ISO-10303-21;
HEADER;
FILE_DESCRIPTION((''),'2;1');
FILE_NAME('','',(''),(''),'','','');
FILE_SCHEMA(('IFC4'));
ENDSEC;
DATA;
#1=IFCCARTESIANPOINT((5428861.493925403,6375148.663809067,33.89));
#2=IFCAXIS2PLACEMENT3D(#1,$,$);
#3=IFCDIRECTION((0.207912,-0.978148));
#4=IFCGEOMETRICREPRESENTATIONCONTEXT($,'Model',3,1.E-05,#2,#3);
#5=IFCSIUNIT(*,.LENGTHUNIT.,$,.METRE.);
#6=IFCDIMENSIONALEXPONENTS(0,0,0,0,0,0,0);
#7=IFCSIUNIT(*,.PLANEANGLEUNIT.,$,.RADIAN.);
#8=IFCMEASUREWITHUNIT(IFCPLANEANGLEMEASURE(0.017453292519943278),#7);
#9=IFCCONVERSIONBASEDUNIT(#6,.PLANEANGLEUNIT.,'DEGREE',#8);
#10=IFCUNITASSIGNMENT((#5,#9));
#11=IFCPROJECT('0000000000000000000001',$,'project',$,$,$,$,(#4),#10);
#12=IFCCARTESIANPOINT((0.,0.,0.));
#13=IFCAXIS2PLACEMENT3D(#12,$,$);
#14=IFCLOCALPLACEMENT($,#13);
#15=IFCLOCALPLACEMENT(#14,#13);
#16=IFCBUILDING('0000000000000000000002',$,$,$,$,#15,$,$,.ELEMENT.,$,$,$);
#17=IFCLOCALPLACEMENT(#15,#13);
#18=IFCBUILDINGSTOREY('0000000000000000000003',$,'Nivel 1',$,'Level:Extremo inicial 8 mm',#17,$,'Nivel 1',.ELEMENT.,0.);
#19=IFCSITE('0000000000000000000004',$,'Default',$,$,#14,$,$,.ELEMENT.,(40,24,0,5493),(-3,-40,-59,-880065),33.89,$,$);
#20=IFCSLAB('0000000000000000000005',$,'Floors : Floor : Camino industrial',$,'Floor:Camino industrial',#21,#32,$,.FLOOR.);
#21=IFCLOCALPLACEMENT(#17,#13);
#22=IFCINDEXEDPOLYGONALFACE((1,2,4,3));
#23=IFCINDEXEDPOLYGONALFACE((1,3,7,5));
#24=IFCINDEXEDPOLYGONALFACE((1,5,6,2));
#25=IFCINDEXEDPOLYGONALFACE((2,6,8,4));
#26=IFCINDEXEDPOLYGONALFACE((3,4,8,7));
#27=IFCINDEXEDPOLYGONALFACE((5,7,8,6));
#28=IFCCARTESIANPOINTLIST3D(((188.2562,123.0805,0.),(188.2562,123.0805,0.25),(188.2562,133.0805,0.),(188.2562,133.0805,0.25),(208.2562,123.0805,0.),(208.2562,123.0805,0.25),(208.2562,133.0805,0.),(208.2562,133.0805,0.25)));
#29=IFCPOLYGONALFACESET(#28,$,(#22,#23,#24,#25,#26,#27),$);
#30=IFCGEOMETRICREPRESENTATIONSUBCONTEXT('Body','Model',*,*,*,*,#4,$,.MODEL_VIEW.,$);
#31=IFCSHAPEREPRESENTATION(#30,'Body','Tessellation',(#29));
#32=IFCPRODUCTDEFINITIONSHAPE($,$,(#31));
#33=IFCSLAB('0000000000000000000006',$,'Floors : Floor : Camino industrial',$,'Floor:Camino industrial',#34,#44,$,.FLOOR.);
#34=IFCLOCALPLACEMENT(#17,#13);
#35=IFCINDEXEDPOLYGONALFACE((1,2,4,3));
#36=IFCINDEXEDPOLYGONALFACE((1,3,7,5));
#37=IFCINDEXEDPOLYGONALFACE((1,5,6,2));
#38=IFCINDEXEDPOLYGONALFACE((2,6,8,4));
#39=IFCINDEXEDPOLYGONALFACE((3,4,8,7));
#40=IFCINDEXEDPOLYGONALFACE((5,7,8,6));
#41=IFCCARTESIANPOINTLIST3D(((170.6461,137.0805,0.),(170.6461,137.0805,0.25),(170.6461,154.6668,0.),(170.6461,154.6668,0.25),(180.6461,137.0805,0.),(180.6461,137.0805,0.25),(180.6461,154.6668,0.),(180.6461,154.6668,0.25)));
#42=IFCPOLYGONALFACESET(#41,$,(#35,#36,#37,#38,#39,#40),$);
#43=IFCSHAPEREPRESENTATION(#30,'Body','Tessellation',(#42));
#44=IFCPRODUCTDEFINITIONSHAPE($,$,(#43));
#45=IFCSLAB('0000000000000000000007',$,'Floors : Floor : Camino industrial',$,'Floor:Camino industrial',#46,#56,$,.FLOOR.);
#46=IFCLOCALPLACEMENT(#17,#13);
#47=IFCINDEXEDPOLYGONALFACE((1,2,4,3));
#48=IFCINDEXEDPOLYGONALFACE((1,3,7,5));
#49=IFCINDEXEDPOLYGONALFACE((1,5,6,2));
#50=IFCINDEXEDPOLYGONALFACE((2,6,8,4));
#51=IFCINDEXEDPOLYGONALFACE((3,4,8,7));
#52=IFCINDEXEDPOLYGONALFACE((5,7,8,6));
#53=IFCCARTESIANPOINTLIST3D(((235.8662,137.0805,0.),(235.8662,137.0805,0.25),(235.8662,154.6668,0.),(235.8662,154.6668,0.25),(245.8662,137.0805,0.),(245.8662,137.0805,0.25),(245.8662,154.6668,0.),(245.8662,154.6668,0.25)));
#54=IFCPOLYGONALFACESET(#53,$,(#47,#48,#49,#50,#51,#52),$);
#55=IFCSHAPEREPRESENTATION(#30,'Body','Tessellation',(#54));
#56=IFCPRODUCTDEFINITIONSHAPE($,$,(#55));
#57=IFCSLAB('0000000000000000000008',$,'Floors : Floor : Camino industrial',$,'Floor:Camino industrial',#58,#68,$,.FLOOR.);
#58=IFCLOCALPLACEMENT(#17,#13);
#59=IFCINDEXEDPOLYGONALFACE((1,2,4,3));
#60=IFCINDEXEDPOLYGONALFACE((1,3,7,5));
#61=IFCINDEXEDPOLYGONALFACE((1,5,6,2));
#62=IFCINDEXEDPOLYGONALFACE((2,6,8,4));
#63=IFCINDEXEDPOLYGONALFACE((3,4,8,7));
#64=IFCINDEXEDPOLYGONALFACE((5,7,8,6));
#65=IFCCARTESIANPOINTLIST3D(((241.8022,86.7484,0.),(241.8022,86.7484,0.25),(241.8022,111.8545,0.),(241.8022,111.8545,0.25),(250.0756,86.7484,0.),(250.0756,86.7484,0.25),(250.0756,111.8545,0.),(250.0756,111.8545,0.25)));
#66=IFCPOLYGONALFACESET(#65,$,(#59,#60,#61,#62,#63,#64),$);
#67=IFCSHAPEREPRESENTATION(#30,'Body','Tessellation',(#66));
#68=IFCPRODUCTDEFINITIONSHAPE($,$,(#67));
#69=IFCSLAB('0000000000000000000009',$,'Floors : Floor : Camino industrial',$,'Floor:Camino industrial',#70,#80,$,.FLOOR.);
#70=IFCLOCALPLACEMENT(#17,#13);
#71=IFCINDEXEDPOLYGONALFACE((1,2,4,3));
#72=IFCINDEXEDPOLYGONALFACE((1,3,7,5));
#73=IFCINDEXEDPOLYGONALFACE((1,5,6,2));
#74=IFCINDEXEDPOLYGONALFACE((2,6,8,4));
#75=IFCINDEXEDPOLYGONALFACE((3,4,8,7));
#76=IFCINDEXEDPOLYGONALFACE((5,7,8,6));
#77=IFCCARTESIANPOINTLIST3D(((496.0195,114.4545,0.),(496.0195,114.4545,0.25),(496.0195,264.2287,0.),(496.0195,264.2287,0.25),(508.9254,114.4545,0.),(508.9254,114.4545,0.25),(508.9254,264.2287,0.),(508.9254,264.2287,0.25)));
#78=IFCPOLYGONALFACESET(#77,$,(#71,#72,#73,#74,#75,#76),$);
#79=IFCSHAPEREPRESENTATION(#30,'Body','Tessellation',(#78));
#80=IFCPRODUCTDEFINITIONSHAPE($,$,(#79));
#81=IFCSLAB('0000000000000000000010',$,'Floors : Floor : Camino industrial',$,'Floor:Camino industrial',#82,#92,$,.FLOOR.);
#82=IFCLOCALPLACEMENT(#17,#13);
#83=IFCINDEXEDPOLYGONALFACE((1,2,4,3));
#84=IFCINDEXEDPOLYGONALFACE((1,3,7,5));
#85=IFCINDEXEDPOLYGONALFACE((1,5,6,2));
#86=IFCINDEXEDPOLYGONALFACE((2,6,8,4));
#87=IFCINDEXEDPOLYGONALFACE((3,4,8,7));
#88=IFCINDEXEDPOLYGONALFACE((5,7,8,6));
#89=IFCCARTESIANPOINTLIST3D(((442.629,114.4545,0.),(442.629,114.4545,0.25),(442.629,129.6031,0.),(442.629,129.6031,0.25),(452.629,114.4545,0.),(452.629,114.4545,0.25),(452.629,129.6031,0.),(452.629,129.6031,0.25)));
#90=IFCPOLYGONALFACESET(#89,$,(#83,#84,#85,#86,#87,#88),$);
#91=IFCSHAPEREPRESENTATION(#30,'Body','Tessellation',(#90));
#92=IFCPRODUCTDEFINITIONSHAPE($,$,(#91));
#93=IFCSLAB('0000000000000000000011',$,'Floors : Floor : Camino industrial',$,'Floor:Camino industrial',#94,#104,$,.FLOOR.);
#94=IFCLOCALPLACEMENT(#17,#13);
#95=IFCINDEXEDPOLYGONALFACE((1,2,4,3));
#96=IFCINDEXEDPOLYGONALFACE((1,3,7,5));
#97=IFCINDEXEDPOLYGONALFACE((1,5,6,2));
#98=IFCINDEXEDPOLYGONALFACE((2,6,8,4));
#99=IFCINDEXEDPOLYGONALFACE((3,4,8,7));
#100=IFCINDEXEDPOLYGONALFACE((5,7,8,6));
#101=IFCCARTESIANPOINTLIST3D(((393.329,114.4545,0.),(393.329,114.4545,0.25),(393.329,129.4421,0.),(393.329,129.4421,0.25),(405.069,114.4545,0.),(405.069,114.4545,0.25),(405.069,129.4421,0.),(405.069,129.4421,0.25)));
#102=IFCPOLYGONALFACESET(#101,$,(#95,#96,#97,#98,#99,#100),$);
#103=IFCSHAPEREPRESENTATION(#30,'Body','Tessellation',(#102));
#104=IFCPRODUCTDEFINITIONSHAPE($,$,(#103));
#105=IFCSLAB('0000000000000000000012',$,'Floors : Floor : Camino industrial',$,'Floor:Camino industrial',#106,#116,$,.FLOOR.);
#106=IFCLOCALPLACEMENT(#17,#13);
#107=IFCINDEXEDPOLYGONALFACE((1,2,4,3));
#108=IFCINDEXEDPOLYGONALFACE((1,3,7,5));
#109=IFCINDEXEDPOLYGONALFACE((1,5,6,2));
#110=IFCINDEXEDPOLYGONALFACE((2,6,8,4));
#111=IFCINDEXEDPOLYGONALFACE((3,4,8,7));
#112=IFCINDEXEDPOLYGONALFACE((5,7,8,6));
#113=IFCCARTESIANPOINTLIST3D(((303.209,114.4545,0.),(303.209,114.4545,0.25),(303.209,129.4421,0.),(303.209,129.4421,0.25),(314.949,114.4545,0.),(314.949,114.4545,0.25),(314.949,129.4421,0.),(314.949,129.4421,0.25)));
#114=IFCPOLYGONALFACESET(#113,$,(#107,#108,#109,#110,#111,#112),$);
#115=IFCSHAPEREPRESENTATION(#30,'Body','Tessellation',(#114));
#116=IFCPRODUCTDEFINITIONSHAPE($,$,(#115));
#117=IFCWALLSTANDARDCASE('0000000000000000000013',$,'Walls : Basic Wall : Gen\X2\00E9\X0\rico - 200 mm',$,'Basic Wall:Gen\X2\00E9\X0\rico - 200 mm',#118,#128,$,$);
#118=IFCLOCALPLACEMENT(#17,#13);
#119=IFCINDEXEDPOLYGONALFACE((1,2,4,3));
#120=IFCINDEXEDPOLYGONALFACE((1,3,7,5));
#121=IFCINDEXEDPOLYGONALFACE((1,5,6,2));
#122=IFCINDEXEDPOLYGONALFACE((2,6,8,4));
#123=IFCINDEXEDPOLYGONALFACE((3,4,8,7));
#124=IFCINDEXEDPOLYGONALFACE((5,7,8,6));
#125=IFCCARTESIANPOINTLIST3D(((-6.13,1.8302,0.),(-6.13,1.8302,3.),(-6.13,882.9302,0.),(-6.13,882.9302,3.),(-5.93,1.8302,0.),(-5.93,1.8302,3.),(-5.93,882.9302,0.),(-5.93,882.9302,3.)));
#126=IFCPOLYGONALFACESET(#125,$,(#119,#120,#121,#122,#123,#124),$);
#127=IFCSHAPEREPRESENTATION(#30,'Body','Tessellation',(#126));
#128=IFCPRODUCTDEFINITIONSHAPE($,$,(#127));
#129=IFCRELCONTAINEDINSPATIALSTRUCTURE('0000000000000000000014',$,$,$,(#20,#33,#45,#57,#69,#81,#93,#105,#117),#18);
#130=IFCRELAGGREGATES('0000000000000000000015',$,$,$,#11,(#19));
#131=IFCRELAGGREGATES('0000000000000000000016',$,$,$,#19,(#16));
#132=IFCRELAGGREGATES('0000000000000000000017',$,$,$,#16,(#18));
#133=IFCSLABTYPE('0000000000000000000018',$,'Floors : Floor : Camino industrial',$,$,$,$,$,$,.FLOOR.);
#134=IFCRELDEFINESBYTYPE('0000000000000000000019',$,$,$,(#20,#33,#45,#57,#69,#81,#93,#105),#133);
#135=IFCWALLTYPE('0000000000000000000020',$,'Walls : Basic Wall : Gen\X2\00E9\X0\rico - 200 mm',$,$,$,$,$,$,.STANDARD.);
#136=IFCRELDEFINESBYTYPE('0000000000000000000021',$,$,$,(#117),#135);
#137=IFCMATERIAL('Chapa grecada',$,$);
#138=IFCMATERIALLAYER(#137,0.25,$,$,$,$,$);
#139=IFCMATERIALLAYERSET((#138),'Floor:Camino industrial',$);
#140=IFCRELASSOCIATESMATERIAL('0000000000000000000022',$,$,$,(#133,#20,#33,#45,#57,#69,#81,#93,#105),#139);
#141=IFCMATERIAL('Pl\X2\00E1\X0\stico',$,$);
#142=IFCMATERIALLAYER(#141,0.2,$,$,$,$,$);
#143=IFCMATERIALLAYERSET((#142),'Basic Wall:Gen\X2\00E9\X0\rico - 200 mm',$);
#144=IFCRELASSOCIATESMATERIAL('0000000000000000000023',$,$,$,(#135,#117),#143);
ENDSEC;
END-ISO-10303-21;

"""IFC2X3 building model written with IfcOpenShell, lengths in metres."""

from ifc_helpers import new_model, entity, si_unit, converted_unit, direction, frame, frame_2d, origin, origin_2d_with_axis, place, context, subcontext, project, spatial, rectangle, extrude, material, layer, layer_set, layer_usage, type_object, element, save


model = new_model("IFC2X3")

# Units and contexts
model_context = context("Model", 3, precision=1e-05, world=frame((5428861.493925403, 6375148.663809067, 33.89)), true_north=direction((0.207912, -0.978148)))
body_context = subcontext(model_context, "Body", "Model", "MODEL_VIEW")
ifc_project = project(units=[si_unit("LENGTHUNIT", "METRE"), converted_unit("PLANEANGLEUNIT", "DEGREE", entity("IfcPlaneAngleMeasure", 0.017453292519943278), si_unit("PLANEANGLEUNIT", "RADIAN"), dimensions=[0, 0, 0, 0, 0, 0, 0])], contexts=[model_context])

# Site, building, storey
site_placement = place(None, origin())
site = spatial("IfcSite", under=ifc_project, at=site_placement, Name="Default", CompositionType="ELEMENT", RefLatitude=(40, 24, 0, 5493), RefLongitude=(-3, -40, -59, -880065), RefElevation=33.89)
building_placement = place(site_placement, origin())
building = spatial("IfcBuilding", under=site, at=building_placement, CompositionType="ELEMENT")
storey_placement = place(building_placement, origin())
storey = spatial("IfcBuildingStorey", under=building, at=storey_placement, Name="Nivel 1", ObjectType="Level:Extremo inicial 8 mm", LongName="Nivel 1", CompositionType="ELEMENT", Elevation=0.0)

# Slabs
ifc_material_1 = material(Name="Chapa grecada")
ifc_layer_1 = layer(ifc_material_1, 0.25)
ifc_layer_set_1 = layer_set([ifc_layer_1], Name="Floor:Camino industrial")
slab_type = type_object("IfcSlabType", Name="Floors : Floor : Camino industrial", PredefinedType="FLOOR", material=ifc_layer_set_1)
ifc_layer_usage_1 = layer_usage(ifc_layer_set_1, "AXIS3", "POSITIVE", 0.0)
slab_1_placement = place(storey_placement, origin())
element("IfcSlab", 1, at=slab_1_placement, inside=storey, type_object=slab_type, material=ifc_layer_usage_1, Name="Floors : Floor : Camino industrial", ObjectType="Floor:Camino industrial", PredefinedType="FLOOR", context=body_context, shape_type="SweptSolid", body=[
    extrude(rectangle(XDim=10.0, YDim=20.0, at=frame_2d((0.0, 0.0), x_axis=(1.0, 0.0))), frame((198.2562, 128.0805, 0.25), z_axis=(0.0, 0.0, -1.0), x_axis=(0.0, 1.0, 0.0)), (0.0, 0.0, 1.0), 0.25),
])
ifc_layer_usage_2 = layer_usage(ifc_layer_set_1, "AXIS3", "POSITIVE", 0.0)
slab_2_placement = place(storey_placement, origin())
element("IfcSlab", 2, at=slab_2_placement, inside=storey, type_object=slab_type, material=ifc_layer_usage_2, Name="Floors : Floor : Camino industrial", ObjectType="Floor:Camino industrial", PredefinedType="FLOOR", context=body_context, shape_type="SweptSolid", body=[
    extrude(rectangle(XDim=17.5863, YDim=10.0, at=origin_2d_with_axis()), frame((175.6461, 145.8736, 0.25), z_axis=(0.0, 0.0, -1.0), x_axis=(0.0, 1.0, 0.0)), (0.0, 0.0, 1.0), 0.25),
])
ifc_layer_usage_3 = layer_usage(ifc_layer_set_1, "AXIS3", "POSITIVE", 0.0)
slab_3_placement = place(storey_placement, origin())
element("IfcSlab", 3, at=slab_3_placement, inside=storey, type_object=slab_type, material=ifc_layer_usage_3, Name="Floors : Floor : Camino industrial", ObjectType="Floor:Camino industrial", PredefinedType="FLOOR", context=body_context, shape_type="SweptSolid", body=[
    extrude(rectangle(XDim=17.5863, YDim=10.0, at=frame_2d((0.0, 0.0), x_axis=(1.0, 0.0))), frame((240.8662, 145.8736, 0.25), z_axis=(0.0, 0.0, -1.0), x_axis=(0.0, 1.0, 0.0)), (0.0, 0.0, 1.0), 0.25),
])
ifc_layer_usage_4 = layer_usage(ifc_layer_set_1, "AXIS3", "POSITIVE", 0.0)
slab_4_placement = place(storey_placement, origin())
element("IfcSlab", 4, at=slab_4_placement, inside=storey, type_object=slab_type, material=ifc_layer_usage_4, Name="Floors : Floor : Camino industrial", ObjectType="Floor:Camino industrial", PredefinedType="FLOOR", context=body_context, shape_type="SweptSolid", body=[
    extrude(rectangle(XDim=25.1061, YDim=8.2734, at=frame_2d((0.0, 0.0), x_axis=(1.0, 0.0))), frame((245.9389, 99.3014, 0.25), z_axis=(0.0, 0.0, -1.0), x_axis=(0.0, 1.0, 0.0)), (0.0, 0.0, 1.0), 0.25),
])
ifc_layer_usage_5 = layer_usage(ifc_layer_set_1, "AXIS3", "POSITIVE", 0.0)
slab_5_placement = place(storey_placement, origin())
element("IfcSlab", 5, at=slab_5_placement, inside=storey, type_object=slab_type, material=ifc_layer_usage_5, Name="Floors : Floor : Camino industrial", ObjectType="Floor:Camino industrial", PredefinedType="FLOOR", context=body_context, shape_type="SweptSolid", body=[
    extrude(rectangle(XDim=149.7742, YDim=12.9059, at=frame_2d((0.0, 0.0), x_axis=(1.0, 0.0))), frame((502.4724, 189.3416, 0.25), z_axis=(0.0, 0.0, -1.0), x_axis=(0.0, 1.0, 0.0)), (0.0, 0.0, 1.0), 0.25),
])
ifc_layer_usage_6 = layer_usage(ifc_layer_set_1, "AXIS3", "POSITIVE", 0.0)
slab_6_placement = place(storey_placement, origin())
element("IfcSlab", 6, at=slab_6_placement, inside=storey, type_object=slab_type, material=ifc_layer_usage_6, Name="Floors : Floor : Camino industrial", ObjectType="Floor:Camino industrial", PredefinedType="FLOOR", context=body_context, shape_type="SweptSolid", body=[
    extrude(rectangle(XDim=15.1486, YDim=10.0, at=frame_2d((0.0, 0.0), x_axis=(1.0, 0.0))), frame((447.629, 122.0288, 0.25), z_axis=(0.0, 0.0, -1.0), x_axis=(0.0, 1.0, 0.0)), (0.0, 0.0, 1.0), 0.25),
])
ifc_layer_usage_7 = layer_usage(ifc_layer_set_1, "AXIS3", "POSITIVE", 0.0)
slab_7_placement = place(storey_placement, origin())
element("IfcSlab", 7, at=slab_7_placement, inside=storey, type_object=slab_type, material=ifc_layer_usage_7, Name="Floors : Floor : Camino industrial", ObjectType="Floor:Camino industrial", PredefinedType="FLOOR", context=body_context, shape_type="SweptSolid", body=[
    extrude(rectangle(XDim=14.9876, YDim=11.74, at=frame_2d((0.0, 0.0), x_axis=(1.0, 0.0))), frame((399.199, 121.9483, 0.25), z_axis=(0.0, 0.0, -1.0), x_axis=(0.0, 1.0, 0.0)), (0.0, 0.0, 1.0), 0.25),
])
ifc_layer_usage_8 = layer_usage(ifc_layer_set_1, "AXIS3", "POSITIVE", 0.0)
slab_8_placement = place(storey_placement, origin())
element("IfcSlab", 8, at=slab_8_placement, inside=storey, type_object=slab_type, material=ifc_layer_usage_8, Name="Floors : Floor : Camino industrial", ObjectType="Floor:Camino industrial", PredefinedType="FLOOR", context=body_context, shape_type="SweptSolid", body=[
    extrude(rectangle(XDim=14.9876, YDim=11.74, at=frame_2d((0.0, 0.0), x_axis=(1.0, 0.0))), frame((309.079, 121.9483, 0.25), z_axis=(0.0, 0.0, -1.0), x_axis=(0.0, 1.0, 0.0)), (0.0, 0.0, 1.0), 0.25),
])

# Wall
ifc_material_2 = material(Name="Plástico")
ifc_layer_2 = layer(ifc_material_2, 0.2)
ifc_layer_set_2 = layer_set([ifc_layer_2], Name="Basic Wall:Genérico - 200 mm")
ifc_layer_usage_9 = layer_usage(ifc_layer_set_2, "AXIS2", "NEGATIVE", 0.1)
wall_type = type_object("IfcWallType", Name="Walls : Basic Wall : Genérico - 200 mm", PredefinedType="STANDARD", material=ifc_layer_set_2)
wall_placement = place(storey_placement, frame((-6.03, 1.8302, 0.0), z_axis=(0.0, 0.0, 1.0), x_axis=(0.0, 1.0, 0.0)))
element("IfcWallStandardCase", 9, at=wall_placement, inside=storey, type_object=wall_type, material=ifc_layer_usage_9, Name="Walls : Basic Wall : Genérico - 200 mm", ObjectType="Basic Wall:Genérico - 200 mm", context=body_context, shape_type="SweptSolid", body=[
    extrude(rectangle(XDim=881.1, YDim=0.2, at=frame_2d((440.55, 0.0), x_axis=(-1.0, 0.0))), origin(), (0.0, 0.0, 1.0), 3.0),
])

save(model, "model.ifc")
